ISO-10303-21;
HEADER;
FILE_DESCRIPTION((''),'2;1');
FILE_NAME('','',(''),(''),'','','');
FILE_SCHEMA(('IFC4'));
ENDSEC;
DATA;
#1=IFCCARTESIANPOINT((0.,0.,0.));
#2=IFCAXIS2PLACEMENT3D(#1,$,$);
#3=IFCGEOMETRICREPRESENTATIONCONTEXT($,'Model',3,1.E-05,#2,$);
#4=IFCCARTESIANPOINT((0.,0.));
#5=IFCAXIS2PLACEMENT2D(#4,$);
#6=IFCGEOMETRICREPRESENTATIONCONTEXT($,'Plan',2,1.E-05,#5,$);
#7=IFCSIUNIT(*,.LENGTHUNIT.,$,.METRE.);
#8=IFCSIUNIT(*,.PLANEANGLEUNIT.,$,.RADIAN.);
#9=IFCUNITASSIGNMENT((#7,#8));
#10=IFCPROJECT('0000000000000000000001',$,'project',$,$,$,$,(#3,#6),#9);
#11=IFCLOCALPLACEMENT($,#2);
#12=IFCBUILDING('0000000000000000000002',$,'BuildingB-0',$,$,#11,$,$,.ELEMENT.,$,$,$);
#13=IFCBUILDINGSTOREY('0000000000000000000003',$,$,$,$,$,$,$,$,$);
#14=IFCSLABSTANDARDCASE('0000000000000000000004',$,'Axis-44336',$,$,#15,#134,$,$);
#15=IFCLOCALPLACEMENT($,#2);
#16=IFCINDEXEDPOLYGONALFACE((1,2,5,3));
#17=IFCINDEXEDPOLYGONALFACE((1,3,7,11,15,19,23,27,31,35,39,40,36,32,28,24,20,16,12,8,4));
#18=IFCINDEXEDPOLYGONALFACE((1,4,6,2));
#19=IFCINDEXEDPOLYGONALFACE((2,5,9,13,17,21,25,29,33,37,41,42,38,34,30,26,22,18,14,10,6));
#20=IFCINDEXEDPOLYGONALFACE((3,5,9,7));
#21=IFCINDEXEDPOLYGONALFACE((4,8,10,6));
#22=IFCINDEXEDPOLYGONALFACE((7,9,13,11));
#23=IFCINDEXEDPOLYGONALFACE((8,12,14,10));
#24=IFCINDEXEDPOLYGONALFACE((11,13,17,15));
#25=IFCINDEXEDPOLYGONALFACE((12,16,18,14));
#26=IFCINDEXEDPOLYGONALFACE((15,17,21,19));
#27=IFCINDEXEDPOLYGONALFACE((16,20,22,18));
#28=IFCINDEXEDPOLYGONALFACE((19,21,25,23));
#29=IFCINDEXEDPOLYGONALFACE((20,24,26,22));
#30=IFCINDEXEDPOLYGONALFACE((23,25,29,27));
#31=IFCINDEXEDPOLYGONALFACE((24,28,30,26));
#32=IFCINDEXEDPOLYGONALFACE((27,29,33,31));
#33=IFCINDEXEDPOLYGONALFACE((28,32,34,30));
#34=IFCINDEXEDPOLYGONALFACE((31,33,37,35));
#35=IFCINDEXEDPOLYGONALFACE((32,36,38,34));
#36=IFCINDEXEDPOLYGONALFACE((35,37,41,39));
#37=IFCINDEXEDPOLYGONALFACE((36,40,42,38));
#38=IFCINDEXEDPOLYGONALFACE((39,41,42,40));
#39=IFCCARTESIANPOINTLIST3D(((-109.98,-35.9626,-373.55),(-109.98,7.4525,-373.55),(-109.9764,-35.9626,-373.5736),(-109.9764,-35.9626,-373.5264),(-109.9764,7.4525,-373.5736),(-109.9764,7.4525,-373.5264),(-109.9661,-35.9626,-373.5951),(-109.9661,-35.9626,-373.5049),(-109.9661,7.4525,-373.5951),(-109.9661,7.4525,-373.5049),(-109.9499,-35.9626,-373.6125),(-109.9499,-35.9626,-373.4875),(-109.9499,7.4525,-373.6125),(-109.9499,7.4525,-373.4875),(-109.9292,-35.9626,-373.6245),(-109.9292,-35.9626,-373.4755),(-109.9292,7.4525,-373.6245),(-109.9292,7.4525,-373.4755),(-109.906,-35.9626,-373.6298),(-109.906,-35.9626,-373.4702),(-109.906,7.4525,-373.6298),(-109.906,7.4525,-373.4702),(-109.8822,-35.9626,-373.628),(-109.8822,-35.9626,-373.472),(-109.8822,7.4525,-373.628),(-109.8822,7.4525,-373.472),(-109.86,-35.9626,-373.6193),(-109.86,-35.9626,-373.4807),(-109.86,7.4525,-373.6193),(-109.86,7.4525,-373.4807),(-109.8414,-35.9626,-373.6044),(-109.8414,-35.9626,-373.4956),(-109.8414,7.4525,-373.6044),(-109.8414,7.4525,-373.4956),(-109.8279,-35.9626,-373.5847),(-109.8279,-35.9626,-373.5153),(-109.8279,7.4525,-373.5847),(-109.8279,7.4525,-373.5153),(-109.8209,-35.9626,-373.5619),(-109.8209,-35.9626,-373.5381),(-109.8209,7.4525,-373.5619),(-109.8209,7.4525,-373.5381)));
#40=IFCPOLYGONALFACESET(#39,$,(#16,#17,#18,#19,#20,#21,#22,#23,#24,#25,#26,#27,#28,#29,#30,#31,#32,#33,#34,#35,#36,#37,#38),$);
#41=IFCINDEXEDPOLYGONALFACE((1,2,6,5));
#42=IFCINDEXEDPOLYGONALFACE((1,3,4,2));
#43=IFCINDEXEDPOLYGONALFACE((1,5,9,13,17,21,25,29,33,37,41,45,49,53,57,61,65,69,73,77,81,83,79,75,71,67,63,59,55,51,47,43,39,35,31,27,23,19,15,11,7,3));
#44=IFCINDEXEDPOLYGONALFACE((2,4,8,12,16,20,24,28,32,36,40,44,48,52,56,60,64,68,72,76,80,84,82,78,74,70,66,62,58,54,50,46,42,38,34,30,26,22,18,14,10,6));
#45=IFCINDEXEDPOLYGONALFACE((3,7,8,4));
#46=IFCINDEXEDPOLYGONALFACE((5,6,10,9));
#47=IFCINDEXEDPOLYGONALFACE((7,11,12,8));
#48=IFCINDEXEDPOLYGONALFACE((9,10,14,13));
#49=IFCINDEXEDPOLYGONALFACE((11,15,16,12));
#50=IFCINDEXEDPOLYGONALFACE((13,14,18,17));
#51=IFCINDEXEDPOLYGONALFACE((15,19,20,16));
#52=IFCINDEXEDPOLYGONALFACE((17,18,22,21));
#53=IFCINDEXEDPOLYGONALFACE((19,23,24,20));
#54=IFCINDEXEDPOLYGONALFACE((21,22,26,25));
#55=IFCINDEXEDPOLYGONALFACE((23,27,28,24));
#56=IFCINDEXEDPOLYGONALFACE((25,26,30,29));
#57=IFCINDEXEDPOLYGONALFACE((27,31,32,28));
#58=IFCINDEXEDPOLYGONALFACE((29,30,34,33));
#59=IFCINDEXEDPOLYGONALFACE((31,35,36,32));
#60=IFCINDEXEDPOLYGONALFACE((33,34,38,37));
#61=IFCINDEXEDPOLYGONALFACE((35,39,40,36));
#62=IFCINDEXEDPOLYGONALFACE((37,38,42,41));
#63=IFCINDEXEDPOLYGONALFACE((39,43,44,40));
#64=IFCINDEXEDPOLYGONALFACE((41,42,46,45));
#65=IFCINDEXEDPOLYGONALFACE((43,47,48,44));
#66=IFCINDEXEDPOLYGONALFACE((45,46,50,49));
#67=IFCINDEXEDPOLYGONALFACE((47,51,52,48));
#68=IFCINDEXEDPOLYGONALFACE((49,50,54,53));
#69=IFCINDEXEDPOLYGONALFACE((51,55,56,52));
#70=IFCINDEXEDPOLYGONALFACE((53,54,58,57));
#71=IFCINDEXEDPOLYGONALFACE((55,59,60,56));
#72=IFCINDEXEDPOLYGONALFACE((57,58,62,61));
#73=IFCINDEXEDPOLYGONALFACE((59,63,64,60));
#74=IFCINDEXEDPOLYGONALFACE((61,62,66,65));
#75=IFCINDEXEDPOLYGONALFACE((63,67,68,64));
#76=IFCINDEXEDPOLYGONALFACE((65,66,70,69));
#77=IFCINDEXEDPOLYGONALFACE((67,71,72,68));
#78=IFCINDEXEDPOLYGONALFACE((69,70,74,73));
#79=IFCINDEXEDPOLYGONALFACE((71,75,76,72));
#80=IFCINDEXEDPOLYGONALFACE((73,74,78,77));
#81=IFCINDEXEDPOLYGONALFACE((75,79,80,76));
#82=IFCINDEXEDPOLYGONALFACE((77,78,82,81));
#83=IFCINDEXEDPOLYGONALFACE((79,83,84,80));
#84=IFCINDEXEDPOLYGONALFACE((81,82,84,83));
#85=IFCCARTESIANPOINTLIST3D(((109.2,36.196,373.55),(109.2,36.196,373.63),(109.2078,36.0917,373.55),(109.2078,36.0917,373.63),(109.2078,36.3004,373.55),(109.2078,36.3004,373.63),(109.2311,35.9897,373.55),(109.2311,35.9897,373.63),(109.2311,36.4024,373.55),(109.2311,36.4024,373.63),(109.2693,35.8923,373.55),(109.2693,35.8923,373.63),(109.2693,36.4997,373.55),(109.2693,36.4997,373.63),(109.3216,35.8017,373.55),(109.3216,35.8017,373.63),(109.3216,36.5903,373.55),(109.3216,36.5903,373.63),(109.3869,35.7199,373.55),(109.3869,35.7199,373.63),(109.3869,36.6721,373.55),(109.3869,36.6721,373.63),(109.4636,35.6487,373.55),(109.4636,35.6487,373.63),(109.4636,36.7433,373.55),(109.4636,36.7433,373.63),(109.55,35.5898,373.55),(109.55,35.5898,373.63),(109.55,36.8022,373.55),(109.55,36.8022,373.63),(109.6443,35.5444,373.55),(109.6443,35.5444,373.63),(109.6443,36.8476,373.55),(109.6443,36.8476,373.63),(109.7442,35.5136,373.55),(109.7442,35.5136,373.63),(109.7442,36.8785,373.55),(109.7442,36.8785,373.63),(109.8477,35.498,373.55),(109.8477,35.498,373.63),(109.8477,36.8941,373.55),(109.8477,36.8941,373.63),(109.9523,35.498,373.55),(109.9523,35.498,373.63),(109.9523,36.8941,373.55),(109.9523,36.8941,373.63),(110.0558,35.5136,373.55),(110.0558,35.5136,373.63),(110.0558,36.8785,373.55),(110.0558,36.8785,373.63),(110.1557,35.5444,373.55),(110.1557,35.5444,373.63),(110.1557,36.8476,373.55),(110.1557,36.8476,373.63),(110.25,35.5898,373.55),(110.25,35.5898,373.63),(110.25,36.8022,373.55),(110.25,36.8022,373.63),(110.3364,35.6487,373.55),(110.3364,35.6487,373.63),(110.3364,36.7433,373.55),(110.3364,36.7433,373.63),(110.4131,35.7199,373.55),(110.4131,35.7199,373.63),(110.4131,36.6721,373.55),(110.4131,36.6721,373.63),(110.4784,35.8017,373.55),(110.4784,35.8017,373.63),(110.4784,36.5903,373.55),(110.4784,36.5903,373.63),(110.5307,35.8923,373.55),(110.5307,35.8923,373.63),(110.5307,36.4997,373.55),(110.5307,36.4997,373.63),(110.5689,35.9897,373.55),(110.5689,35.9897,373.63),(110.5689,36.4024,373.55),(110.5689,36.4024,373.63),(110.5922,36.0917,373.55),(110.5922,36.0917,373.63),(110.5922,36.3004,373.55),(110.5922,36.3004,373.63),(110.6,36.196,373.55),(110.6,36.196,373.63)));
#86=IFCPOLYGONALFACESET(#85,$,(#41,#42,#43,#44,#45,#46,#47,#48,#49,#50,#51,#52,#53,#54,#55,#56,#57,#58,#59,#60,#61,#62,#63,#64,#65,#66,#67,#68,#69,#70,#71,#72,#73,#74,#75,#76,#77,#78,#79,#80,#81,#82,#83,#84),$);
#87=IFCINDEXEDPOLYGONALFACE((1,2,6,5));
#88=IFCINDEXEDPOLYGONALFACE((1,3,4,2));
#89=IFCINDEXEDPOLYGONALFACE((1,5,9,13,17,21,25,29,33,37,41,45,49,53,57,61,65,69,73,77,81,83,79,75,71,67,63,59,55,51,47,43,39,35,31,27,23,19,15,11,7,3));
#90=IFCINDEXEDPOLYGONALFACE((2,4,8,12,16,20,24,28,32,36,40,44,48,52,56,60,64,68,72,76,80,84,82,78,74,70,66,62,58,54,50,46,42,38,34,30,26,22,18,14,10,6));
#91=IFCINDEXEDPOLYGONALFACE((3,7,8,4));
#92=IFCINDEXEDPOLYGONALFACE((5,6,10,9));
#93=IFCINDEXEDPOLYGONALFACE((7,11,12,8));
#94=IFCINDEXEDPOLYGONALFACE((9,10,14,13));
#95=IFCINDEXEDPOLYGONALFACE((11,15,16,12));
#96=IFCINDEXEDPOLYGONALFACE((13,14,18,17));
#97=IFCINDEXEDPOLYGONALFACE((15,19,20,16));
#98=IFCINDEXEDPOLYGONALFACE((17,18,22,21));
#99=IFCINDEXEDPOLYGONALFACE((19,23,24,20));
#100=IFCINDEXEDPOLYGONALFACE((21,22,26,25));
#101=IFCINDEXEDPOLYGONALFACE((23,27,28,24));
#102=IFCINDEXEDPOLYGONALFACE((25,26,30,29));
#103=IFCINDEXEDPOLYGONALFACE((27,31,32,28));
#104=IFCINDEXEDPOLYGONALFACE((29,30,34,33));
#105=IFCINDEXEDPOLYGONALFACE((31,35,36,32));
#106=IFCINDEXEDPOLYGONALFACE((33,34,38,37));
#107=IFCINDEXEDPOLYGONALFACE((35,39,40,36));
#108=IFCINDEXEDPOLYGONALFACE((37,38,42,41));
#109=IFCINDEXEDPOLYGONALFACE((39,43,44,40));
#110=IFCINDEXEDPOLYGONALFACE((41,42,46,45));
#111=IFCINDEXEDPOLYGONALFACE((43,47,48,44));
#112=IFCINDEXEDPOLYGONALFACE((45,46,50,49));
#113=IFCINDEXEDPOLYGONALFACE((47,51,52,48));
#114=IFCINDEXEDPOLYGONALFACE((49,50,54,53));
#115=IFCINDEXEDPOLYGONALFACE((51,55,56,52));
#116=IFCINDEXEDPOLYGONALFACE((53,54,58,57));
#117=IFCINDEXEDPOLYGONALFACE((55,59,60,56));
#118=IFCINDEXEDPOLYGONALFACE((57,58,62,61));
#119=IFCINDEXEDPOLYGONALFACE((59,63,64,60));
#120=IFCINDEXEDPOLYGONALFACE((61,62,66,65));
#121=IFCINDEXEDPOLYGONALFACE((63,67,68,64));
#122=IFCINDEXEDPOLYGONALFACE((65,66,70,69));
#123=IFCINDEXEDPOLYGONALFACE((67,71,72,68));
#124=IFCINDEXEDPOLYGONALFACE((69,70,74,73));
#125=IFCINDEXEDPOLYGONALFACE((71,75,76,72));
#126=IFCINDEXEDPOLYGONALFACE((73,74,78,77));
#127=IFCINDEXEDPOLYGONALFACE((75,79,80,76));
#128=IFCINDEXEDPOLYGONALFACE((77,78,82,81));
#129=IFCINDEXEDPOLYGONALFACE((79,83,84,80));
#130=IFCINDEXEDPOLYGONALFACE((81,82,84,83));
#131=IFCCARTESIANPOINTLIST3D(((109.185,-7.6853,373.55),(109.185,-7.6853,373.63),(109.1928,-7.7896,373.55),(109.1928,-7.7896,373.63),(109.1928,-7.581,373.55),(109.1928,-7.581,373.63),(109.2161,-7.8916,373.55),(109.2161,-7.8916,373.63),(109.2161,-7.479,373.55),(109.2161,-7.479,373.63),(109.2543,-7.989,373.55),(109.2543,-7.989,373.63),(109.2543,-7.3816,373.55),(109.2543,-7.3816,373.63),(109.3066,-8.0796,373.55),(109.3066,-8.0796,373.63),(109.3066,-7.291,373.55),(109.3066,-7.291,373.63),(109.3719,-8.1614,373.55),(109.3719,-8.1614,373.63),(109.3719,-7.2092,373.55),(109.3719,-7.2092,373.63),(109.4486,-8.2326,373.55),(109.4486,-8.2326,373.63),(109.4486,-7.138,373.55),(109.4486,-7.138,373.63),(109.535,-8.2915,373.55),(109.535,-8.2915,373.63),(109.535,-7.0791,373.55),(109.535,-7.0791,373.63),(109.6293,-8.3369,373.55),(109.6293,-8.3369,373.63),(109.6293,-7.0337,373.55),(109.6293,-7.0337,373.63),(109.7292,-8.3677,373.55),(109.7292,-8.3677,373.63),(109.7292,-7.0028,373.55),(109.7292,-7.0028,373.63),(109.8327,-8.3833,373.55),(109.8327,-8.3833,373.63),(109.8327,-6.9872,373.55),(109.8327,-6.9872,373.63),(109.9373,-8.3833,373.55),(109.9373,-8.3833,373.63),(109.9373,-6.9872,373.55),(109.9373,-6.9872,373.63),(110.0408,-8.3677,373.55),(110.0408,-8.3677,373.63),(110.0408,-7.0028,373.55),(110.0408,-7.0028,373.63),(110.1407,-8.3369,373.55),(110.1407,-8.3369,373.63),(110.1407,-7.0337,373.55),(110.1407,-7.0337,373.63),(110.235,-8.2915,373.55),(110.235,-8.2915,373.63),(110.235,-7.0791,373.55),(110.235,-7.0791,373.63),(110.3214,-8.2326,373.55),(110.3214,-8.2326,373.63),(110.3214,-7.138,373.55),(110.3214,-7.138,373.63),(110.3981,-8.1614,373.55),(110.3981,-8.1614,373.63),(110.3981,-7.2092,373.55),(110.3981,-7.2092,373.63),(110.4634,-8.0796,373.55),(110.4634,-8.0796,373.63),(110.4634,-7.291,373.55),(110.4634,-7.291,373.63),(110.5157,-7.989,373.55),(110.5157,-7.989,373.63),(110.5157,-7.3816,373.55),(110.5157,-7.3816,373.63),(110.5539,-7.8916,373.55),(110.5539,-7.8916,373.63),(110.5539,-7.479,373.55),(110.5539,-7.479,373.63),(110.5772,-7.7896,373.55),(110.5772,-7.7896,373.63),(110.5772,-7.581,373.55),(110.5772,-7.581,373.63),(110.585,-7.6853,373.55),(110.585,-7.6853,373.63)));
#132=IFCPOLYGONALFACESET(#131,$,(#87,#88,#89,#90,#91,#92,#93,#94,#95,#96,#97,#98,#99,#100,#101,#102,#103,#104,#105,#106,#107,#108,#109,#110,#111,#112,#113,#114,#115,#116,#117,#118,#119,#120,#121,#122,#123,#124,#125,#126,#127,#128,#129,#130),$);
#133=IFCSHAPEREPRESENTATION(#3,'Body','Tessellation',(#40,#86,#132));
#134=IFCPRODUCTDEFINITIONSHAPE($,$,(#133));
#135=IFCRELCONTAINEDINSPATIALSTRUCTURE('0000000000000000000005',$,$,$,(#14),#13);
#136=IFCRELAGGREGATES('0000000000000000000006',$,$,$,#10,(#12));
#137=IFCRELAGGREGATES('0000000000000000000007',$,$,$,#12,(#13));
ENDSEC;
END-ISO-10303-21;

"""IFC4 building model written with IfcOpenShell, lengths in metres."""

from ifc_helpers import new_model, entity, si_unit, frame, origin, origin_2d, place, context, project, spatial, circle, extrude, element, save


model = new_model("IFC4")

# Units and contexts
model_context = context("Model", 3, precision=1e-05, world=origin())
plan_context = context("Plan", 2, precision=1e-05, world=origin_2d())
ifc_project = project(units=[si_unit("LENGTHUNIT", "METRE"), si_unit("PLANEANGLEUNIT", "RADIAN")], contexts=[model_context, plan_context])

# Building, storey
building_placement = place(None, origin())
building = spatial("IfcBuilding", under=ifc_project, at=building_placement, Name="BuildingB-0", CompositionType="ELEMENT")
storey = spatial("IfcBuildingStorey", under=building)

# Slab
element("IfcSlabStandardCase", 1, inside=storey, Name="Axis-44336", context=model_context, shape_type="AdvancedSweptSolid", body=[
    entity("IfcSurfaceCurveSweptAreaSolid", entity("IfcCircleProfileDef", "AREA", None, None, 0.08), None, entity("IfcPolyline", [entity("IfcCartesianPoint", [109.9, 35.9626, 373.55]), entity("IfcCartesianPoint", [109.9, -7.4525, 373.55])]), None, None, entity("IfcPlane", entity("IfcAxis2Placement3D", entity("IfcCartesianPoint", [109.9, 35.9626, 373.55]), entity("IfcDirection", [0.0, 0.0, 1.0]), entity("IfcDirection", [1.0, 0.0, 0.0])))),
    extrude(circle(Radius=0.7), frame((109.9, 36.196, 373.55)), (0.0, 0.0, 1.0), 0.08),
    extrude(circle(Radius=0.7), frame((109.885, -7.6853, 373.55)), (0.0, 0.0, 1.0), 0.08),
])

save(model, "model.ifc")
